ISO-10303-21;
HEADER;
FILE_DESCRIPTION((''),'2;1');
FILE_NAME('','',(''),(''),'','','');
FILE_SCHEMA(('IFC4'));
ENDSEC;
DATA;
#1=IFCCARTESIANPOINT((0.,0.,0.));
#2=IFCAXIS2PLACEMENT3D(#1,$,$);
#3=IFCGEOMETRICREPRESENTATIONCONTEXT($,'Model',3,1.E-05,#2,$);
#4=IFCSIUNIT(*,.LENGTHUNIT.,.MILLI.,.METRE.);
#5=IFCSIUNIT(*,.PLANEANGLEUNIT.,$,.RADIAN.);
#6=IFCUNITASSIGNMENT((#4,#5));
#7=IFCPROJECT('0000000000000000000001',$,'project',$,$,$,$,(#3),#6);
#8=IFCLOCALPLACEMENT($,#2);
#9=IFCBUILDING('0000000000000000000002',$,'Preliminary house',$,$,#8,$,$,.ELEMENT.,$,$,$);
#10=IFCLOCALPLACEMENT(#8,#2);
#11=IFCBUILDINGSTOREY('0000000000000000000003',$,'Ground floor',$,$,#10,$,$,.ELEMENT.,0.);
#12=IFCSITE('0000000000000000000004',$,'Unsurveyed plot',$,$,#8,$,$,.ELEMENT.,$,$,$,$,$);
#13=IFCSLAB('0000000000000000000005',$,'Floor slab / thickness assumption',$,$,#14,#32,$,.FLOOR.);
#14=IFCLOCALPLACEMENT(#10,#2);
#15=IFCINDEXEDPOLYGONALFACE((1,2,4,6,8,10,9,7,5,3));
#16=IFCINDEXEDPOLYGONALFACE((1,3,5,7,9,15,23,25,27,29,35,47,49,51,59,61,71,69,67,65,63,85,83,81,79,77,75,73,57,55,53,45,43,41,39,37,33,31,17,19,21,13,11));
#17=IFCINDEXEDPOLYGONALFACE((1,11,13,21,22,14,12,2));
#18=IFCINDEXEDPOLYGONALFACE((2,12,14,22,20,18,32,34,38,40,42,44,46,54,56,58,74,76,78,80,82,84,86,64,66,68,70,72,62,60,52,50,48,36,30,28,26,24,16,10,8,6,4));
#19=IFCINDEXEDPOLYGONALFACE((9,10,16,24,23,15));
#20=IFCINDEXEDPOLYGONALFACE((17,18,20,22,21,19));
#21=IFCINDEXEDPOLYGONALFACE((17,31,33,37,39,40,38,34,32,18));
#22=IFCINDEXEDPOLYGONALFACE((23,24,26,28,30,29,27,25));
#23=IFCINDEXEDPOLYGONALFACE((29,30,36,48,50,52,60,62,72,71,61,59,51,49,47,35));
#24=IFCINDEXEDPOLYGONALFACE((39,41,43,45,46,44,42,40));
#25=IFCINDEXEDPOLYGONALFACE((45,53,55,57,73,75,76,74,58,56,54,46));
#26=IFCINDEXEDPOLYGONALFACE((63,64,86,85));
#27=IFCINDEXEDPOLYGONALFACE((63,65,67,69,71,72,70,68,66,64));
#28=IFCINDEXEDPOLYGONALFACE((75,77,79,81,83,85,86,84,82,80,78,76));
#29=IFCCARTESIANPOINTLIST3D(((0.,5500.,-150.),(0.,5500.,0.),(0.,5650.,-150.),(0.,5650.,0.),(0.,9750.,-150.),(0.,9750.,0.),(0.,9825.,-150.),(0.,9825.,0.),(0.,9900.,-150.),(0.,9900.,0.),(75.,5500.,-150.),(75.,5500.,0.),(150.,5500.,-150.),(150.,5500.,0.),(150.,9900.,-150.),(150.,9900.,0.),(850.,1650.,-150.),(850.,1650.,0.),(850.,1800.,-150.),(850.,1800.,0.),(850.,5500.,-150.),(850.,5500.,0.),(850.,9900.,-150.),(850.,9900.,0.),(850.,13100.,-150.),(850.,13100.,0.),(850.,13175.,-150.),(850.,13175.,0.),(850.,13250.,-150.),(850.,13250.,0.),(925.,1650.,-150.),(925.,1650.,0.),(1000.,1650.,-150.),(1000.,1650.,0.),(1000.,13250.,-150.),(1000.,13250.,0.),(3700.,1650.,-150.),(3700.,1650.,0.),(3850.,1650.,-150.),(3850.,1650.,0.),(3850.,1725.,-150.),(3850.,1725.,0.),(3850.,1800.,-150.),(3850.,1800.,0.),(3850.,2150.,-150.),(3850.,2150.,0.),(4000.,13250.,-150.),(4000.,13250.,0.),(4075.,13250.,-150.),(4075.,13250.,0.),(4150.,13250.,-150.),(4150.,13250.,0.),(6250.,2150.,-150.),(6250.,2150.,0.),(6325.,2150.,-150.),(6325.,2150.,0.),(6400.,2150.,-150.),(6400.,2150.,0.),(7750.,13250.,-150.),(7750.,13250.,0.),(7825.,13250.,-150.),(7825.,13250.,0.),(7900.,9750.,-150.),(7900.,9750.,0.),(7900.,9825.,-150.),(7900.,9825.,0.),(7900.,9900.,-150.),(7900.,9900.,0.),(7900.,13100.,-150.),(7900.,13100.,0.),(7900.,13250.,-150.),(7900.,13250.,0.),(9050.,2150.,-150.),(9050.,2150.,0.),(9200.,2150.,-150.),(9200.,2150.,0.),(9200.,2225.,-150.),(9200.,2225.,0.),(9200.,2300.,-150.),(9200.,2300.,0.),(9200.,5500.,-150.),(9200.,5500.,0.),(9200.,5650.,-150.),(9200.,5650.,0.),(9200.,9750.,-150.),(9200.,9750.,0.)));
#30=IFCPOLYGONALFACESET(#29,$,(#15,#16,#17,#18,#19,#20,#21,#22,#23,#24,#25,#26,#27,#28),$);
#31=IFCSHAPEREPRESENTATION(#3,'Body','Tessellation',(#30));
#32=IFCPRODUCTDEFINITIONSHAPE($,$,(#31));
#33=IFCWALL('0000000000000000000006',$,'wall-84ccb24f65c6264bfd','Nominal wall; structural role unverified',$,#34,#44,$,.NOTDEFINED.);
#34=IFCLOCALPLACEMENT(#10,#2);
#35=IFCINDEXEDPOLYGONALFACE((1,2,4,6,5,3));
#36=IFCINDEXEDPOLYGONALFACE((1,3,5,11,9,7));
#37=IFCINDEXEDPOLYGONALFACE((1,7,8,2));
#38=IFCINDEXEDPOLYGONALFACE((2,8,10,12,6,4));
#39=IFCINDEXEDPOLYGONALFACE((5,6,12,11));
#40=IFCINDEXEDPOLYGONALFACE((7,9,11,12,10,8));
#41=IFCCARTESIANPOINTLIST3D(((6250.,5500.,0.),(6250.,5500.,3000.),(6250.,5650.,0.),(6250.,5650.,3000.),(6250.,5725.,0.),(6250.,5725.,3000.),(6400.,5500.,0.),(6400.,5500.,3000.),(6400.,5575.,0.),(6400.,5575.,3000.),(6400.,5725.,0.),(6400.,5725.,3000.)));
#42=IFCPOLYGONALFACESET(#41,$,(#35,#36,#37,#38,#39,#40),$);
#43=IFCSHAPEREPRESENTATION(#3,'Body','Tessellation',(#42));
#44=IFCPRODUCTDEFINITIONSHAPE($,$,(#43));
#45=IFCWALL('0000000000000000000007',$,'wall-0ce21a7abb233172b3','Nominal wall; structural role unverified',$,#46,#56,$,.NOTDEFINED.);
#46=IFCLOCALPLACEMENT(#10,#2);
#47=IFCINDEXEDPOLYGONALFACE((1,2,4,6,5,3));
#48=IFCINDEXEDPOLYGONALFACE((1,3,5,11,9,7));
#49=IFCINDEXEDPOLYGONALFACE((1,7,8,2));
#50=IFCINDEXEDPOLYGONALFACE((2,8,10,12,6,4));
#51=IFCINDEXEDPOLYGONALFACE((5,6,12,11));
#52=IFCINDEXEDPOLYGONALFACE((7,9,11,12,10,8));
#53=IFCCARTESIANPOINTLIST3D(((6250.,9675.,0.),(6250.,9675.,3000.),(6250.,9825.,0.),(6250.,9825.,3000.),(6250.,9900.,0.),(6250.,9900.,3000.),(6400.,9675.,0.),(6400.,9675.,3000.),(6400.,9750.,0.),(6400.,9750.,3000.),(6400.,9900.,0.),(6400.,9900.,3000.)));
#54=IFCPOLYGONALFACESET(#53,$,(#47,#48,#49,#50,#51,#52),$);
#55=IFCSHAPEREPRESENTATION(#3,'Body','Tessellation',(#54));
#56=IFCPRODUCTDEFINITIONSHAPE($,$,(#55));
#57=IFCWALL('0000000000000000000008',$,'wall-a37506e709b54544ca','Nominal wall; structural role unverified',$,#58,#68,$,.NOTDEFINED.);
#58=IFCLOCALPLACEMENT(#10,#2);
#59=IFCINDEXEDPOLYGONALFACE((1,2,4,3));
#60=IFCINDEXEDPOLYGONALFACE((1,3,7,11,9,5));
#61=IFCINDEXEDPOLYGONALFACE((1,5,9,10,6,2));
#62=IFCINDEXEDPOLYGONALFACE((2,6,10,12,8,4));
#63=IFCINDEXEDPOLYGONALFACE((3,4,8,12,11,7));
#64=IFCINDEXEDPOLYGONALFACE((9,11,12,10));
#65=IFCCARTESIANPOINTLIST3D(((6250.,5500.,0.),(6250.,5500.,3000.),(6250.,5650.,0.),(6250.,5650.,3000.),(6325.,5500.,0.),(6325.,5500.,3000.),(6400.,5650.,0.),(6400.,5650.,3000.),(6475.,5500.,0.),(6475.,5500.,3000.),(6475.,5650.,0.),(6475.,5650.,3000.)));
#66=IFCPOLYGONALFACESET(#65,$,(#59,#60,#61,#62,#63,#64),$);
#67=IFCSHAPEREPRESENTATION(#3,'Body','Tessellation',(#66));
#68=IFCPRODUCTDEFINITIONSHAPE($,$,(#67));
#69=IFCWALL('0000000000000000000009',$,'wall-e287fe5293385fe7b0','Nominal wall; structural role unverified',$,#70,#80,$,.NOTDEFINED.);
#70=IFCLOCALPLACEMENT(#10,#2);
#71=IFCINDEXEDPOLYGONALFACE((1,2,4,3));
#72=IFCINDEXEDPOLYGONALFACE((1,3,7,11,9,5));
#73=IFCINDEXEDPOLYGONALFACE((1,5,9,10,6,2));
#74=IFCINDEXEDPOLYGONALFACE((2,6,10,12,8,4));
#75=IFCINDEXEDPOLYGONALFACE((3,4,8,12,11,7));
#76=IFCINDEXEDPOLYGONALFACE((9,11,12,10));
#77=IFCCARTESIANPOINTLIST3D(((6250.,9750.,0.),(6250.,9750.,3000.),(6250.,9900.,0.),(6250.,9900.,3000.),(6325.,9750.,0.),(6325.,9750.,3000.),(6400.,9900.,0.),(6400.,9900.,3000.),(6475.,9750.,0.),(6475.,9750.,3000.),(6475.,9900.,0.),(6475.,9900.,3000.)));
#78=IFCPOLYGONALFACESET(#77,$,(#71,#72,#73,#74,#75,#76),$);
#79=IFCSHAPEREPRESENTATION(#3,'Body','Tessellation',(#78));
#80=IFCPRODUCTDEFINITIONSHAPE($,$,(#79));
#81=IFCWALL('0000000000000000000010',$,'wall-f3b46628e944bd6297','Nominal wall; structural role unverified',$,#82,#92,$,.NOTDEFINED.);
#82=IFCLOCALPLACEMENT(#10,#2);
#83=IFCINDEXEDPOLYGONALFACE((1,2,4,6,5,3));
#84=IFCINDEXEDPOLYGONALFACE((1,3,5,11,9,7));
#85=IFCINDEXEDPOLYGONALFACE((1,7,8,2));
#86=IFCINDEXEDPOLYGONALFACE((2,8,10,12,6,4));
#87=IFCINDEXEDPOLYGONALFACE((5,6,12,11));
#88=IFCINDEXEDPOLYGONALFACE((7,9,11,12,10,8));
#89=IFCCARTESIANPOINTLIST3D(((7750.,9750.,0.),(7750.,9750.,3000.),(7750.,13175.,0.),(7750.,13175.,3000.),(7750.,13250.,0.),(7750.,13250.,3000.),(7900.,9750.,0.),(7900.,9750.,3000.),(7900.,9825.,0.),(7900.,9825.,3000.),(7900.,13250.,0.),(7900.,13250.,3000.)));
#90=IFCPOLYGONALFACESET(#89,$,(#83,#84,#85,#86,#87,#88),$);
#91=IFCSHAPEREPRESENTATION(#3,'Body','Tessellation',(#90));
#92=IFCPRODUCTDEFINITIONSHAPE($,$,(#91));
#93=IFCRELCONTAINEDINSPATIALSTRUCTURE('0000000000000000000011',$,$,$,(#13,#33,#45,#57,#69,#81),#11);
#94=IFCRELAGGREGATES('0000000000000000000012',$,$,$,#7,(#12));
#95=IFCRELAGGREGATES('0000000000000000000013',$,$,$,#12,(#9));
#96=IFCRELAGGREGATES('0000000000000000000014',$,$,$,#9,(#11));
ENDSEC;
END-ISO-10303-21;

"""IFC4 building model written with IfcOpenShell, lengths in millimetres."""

from ifc_helpers import new_model, si_unit, frame, origin, place, context, project, spatial, polyline, outline, extrude, element, save


model = new_model("IFC4")

# Units and contexts
model_context = context("Model", 3, precision=1e-05, world=origin())
ifc_project = project(units=[si_unit("LENGTHUNIT", "METRE", prefix="MILLI"), si_unit("PLANEANGLEUNIT", "RADIAN")], contexts=[model_context])

# Site, building, storey
placement_1 = place(None, origin())
site = spatial("IfcSite", under=ifc_project, at=placement_1, Name="Unsurveyed plot", CompositionType="ELEMENT")
building = spatial("IfcBuilding", under=site, at=placement_1, Name="Preliminary house", CompositionType="ELEMENT")
placement_2 = place(placement_1, origin())
storey = spatial("IfcBuildingStorey", under=building, at=placement_2, Name="Ground floor", CompositionType="ELEMENT", Elevation=0.0)

# Slab
element("IfcSlab", 1, at=placement_2, inside=storey, Name="Floor slab / thickness assumption", PredefinedType="FLOOR", context=model_context, shape_type="SweptSolid", body=[
    extrude(outline(polyline([(925.0, 1650.0), (850.0, 1650.0), (850.0, 1800.0), (850.0, 5500.0), (150.0, 5500.0), (75.0, 5500.0), (0.0, 5500.0), (0.0, 5650.0), (0.0, 9750.0), (0.0, 9825.0), (0.0, 9900.0), (150.0, 9900.0), (850.0, 9900.0), (850.0, 13100.0), (850.0, 13175.0), (850.0, 13250.0), (1000.0, 13250.0), (4000.0, 13250.0), (4075.0, 13250.0), (4150.0, 13250.0), (7750.0, 13250.0), (7825.0, 13250.0), (7900.0, 13250.0), (7900.0, 13100.0), (7900.0, 9900.0), (7900.0, 9825.0), (7900.0, 9750.0), (9200.0, 9750.0), (9200.0, 5650.0), (9200.0, 5500.0), (9200.0, 2300.0), (9200.0, 2225.0), (9200.0, 2150.0), (9050.0, 2150.0), (6400.0, 2150.0), (6325.0, 2150.0), (6250.0, 2150.0), (3850.0, 2150.0), (3850.0, 1800.0), (3850.0, 1725.0), (3850.0, 1650.0), (3700.0, 1650.0), (1000.0, 1650.0), (925.0, 1650.0)])), frame((0.0, 0.0, -150.0)), (0.0, 0.0, 1.0), 150.0),
])

# Wall
element("IfcWall", 2, at=placement_2, inside=storey, Name="wall-84ccb24f65c6264bfd", Description="Nominal wall; structural role unverified", PredefinedType="NOTDEFINED", context=model_context, shape_type="SweptSolid", body=[
    extrude(outline(polyline([(6250.0, 5650.0), (6250.0, 5725.0), (6400.0, 5725.0), (6400.0, 5575.0), (6400.0, 5500.0), (6250.0, 5500.0), (6250.0, 5650.0)])), origin(), (0.0, 0.0, 1.0), 3000.0),
])

# Walls
element("IfcWall", 3, at=placement_2, inside=storey, Name="wall-0ce21a7abb233172b3", Description="Nominal wall; structural role unverified", PredefinedType="NOTDEFINED", context=model_context, shape_type="SweptSolid", body=[
    extrude(outline(polyline([(6250.0, 9825.0), (6250.0, 9900.0), (6400.0, 9900.0), (6400.0, 9750.0), (6400.0, 9675.0), (6250.0, 9675.0), (6250.0, 9825.0)])), origin(), (0.0, 0.0, 1.0), 3000.0),
])
element("IfcWall", 4, at=placement_2, inside=storey, Name="wall-a37506e709b54544ca", Description="Nominal wall; structural role unverified", PredefinedType="NOTDEFINED", context=model_context, shape_type="SweptSolid", body=[
    extrude(outline(polyline([(6400.0, 5650.0), (6475.0, 5650.0), (6475.0, 5500.0), (6325.0, 5500.0), (6250.0, 5500.0), (6250.0, 5650.0), (6400.0, 5650.0)])), origin(), (0.0, 0.0, 1.0), 3000.0),
])

# Wall
element("IfcWall", 5, at=placement_2, inside=storey, Name="wall-e287fe5293385fe7b0", Description="Nominal wall; structural role unverified", PredefinedType="NOTDEFINED", context=model_context, shape_type="SweptSolid", body=[
    extrude(outline(polyline([(6400.0, 9900.0), (6475.0, 9900.0), (6475.0, 9750.0), (6325.0, 9750.0), (6250.0, 9750.0), (6250.0, 9900.0), (6400.0, 9900.0)])), origin(), (0.0, 0.0, 1.0), 3000.0),
])

# Wall
element("IfcWall", 6, at=placement_2, inside=storey, Name="wall-f3b46628e944bd6297", Description="Nominal wall; structural role unverified", PredefinedType="NOTDEFINED", context=model_context, shape_type="SweptSolid", body=[
    extrude(outline(polyline([(7750.0, 13175.0), (7750.0, 13250.0), (7900.0, 13250.0), (7900.0, 9825.0), (7900.0, 9750.0), (7750.0, 9750.0), (7750.0, 13175.0)])), origin(), (0.0, 0.0, 1.0), 3000.0),
])

save(model, "model.ifc")
